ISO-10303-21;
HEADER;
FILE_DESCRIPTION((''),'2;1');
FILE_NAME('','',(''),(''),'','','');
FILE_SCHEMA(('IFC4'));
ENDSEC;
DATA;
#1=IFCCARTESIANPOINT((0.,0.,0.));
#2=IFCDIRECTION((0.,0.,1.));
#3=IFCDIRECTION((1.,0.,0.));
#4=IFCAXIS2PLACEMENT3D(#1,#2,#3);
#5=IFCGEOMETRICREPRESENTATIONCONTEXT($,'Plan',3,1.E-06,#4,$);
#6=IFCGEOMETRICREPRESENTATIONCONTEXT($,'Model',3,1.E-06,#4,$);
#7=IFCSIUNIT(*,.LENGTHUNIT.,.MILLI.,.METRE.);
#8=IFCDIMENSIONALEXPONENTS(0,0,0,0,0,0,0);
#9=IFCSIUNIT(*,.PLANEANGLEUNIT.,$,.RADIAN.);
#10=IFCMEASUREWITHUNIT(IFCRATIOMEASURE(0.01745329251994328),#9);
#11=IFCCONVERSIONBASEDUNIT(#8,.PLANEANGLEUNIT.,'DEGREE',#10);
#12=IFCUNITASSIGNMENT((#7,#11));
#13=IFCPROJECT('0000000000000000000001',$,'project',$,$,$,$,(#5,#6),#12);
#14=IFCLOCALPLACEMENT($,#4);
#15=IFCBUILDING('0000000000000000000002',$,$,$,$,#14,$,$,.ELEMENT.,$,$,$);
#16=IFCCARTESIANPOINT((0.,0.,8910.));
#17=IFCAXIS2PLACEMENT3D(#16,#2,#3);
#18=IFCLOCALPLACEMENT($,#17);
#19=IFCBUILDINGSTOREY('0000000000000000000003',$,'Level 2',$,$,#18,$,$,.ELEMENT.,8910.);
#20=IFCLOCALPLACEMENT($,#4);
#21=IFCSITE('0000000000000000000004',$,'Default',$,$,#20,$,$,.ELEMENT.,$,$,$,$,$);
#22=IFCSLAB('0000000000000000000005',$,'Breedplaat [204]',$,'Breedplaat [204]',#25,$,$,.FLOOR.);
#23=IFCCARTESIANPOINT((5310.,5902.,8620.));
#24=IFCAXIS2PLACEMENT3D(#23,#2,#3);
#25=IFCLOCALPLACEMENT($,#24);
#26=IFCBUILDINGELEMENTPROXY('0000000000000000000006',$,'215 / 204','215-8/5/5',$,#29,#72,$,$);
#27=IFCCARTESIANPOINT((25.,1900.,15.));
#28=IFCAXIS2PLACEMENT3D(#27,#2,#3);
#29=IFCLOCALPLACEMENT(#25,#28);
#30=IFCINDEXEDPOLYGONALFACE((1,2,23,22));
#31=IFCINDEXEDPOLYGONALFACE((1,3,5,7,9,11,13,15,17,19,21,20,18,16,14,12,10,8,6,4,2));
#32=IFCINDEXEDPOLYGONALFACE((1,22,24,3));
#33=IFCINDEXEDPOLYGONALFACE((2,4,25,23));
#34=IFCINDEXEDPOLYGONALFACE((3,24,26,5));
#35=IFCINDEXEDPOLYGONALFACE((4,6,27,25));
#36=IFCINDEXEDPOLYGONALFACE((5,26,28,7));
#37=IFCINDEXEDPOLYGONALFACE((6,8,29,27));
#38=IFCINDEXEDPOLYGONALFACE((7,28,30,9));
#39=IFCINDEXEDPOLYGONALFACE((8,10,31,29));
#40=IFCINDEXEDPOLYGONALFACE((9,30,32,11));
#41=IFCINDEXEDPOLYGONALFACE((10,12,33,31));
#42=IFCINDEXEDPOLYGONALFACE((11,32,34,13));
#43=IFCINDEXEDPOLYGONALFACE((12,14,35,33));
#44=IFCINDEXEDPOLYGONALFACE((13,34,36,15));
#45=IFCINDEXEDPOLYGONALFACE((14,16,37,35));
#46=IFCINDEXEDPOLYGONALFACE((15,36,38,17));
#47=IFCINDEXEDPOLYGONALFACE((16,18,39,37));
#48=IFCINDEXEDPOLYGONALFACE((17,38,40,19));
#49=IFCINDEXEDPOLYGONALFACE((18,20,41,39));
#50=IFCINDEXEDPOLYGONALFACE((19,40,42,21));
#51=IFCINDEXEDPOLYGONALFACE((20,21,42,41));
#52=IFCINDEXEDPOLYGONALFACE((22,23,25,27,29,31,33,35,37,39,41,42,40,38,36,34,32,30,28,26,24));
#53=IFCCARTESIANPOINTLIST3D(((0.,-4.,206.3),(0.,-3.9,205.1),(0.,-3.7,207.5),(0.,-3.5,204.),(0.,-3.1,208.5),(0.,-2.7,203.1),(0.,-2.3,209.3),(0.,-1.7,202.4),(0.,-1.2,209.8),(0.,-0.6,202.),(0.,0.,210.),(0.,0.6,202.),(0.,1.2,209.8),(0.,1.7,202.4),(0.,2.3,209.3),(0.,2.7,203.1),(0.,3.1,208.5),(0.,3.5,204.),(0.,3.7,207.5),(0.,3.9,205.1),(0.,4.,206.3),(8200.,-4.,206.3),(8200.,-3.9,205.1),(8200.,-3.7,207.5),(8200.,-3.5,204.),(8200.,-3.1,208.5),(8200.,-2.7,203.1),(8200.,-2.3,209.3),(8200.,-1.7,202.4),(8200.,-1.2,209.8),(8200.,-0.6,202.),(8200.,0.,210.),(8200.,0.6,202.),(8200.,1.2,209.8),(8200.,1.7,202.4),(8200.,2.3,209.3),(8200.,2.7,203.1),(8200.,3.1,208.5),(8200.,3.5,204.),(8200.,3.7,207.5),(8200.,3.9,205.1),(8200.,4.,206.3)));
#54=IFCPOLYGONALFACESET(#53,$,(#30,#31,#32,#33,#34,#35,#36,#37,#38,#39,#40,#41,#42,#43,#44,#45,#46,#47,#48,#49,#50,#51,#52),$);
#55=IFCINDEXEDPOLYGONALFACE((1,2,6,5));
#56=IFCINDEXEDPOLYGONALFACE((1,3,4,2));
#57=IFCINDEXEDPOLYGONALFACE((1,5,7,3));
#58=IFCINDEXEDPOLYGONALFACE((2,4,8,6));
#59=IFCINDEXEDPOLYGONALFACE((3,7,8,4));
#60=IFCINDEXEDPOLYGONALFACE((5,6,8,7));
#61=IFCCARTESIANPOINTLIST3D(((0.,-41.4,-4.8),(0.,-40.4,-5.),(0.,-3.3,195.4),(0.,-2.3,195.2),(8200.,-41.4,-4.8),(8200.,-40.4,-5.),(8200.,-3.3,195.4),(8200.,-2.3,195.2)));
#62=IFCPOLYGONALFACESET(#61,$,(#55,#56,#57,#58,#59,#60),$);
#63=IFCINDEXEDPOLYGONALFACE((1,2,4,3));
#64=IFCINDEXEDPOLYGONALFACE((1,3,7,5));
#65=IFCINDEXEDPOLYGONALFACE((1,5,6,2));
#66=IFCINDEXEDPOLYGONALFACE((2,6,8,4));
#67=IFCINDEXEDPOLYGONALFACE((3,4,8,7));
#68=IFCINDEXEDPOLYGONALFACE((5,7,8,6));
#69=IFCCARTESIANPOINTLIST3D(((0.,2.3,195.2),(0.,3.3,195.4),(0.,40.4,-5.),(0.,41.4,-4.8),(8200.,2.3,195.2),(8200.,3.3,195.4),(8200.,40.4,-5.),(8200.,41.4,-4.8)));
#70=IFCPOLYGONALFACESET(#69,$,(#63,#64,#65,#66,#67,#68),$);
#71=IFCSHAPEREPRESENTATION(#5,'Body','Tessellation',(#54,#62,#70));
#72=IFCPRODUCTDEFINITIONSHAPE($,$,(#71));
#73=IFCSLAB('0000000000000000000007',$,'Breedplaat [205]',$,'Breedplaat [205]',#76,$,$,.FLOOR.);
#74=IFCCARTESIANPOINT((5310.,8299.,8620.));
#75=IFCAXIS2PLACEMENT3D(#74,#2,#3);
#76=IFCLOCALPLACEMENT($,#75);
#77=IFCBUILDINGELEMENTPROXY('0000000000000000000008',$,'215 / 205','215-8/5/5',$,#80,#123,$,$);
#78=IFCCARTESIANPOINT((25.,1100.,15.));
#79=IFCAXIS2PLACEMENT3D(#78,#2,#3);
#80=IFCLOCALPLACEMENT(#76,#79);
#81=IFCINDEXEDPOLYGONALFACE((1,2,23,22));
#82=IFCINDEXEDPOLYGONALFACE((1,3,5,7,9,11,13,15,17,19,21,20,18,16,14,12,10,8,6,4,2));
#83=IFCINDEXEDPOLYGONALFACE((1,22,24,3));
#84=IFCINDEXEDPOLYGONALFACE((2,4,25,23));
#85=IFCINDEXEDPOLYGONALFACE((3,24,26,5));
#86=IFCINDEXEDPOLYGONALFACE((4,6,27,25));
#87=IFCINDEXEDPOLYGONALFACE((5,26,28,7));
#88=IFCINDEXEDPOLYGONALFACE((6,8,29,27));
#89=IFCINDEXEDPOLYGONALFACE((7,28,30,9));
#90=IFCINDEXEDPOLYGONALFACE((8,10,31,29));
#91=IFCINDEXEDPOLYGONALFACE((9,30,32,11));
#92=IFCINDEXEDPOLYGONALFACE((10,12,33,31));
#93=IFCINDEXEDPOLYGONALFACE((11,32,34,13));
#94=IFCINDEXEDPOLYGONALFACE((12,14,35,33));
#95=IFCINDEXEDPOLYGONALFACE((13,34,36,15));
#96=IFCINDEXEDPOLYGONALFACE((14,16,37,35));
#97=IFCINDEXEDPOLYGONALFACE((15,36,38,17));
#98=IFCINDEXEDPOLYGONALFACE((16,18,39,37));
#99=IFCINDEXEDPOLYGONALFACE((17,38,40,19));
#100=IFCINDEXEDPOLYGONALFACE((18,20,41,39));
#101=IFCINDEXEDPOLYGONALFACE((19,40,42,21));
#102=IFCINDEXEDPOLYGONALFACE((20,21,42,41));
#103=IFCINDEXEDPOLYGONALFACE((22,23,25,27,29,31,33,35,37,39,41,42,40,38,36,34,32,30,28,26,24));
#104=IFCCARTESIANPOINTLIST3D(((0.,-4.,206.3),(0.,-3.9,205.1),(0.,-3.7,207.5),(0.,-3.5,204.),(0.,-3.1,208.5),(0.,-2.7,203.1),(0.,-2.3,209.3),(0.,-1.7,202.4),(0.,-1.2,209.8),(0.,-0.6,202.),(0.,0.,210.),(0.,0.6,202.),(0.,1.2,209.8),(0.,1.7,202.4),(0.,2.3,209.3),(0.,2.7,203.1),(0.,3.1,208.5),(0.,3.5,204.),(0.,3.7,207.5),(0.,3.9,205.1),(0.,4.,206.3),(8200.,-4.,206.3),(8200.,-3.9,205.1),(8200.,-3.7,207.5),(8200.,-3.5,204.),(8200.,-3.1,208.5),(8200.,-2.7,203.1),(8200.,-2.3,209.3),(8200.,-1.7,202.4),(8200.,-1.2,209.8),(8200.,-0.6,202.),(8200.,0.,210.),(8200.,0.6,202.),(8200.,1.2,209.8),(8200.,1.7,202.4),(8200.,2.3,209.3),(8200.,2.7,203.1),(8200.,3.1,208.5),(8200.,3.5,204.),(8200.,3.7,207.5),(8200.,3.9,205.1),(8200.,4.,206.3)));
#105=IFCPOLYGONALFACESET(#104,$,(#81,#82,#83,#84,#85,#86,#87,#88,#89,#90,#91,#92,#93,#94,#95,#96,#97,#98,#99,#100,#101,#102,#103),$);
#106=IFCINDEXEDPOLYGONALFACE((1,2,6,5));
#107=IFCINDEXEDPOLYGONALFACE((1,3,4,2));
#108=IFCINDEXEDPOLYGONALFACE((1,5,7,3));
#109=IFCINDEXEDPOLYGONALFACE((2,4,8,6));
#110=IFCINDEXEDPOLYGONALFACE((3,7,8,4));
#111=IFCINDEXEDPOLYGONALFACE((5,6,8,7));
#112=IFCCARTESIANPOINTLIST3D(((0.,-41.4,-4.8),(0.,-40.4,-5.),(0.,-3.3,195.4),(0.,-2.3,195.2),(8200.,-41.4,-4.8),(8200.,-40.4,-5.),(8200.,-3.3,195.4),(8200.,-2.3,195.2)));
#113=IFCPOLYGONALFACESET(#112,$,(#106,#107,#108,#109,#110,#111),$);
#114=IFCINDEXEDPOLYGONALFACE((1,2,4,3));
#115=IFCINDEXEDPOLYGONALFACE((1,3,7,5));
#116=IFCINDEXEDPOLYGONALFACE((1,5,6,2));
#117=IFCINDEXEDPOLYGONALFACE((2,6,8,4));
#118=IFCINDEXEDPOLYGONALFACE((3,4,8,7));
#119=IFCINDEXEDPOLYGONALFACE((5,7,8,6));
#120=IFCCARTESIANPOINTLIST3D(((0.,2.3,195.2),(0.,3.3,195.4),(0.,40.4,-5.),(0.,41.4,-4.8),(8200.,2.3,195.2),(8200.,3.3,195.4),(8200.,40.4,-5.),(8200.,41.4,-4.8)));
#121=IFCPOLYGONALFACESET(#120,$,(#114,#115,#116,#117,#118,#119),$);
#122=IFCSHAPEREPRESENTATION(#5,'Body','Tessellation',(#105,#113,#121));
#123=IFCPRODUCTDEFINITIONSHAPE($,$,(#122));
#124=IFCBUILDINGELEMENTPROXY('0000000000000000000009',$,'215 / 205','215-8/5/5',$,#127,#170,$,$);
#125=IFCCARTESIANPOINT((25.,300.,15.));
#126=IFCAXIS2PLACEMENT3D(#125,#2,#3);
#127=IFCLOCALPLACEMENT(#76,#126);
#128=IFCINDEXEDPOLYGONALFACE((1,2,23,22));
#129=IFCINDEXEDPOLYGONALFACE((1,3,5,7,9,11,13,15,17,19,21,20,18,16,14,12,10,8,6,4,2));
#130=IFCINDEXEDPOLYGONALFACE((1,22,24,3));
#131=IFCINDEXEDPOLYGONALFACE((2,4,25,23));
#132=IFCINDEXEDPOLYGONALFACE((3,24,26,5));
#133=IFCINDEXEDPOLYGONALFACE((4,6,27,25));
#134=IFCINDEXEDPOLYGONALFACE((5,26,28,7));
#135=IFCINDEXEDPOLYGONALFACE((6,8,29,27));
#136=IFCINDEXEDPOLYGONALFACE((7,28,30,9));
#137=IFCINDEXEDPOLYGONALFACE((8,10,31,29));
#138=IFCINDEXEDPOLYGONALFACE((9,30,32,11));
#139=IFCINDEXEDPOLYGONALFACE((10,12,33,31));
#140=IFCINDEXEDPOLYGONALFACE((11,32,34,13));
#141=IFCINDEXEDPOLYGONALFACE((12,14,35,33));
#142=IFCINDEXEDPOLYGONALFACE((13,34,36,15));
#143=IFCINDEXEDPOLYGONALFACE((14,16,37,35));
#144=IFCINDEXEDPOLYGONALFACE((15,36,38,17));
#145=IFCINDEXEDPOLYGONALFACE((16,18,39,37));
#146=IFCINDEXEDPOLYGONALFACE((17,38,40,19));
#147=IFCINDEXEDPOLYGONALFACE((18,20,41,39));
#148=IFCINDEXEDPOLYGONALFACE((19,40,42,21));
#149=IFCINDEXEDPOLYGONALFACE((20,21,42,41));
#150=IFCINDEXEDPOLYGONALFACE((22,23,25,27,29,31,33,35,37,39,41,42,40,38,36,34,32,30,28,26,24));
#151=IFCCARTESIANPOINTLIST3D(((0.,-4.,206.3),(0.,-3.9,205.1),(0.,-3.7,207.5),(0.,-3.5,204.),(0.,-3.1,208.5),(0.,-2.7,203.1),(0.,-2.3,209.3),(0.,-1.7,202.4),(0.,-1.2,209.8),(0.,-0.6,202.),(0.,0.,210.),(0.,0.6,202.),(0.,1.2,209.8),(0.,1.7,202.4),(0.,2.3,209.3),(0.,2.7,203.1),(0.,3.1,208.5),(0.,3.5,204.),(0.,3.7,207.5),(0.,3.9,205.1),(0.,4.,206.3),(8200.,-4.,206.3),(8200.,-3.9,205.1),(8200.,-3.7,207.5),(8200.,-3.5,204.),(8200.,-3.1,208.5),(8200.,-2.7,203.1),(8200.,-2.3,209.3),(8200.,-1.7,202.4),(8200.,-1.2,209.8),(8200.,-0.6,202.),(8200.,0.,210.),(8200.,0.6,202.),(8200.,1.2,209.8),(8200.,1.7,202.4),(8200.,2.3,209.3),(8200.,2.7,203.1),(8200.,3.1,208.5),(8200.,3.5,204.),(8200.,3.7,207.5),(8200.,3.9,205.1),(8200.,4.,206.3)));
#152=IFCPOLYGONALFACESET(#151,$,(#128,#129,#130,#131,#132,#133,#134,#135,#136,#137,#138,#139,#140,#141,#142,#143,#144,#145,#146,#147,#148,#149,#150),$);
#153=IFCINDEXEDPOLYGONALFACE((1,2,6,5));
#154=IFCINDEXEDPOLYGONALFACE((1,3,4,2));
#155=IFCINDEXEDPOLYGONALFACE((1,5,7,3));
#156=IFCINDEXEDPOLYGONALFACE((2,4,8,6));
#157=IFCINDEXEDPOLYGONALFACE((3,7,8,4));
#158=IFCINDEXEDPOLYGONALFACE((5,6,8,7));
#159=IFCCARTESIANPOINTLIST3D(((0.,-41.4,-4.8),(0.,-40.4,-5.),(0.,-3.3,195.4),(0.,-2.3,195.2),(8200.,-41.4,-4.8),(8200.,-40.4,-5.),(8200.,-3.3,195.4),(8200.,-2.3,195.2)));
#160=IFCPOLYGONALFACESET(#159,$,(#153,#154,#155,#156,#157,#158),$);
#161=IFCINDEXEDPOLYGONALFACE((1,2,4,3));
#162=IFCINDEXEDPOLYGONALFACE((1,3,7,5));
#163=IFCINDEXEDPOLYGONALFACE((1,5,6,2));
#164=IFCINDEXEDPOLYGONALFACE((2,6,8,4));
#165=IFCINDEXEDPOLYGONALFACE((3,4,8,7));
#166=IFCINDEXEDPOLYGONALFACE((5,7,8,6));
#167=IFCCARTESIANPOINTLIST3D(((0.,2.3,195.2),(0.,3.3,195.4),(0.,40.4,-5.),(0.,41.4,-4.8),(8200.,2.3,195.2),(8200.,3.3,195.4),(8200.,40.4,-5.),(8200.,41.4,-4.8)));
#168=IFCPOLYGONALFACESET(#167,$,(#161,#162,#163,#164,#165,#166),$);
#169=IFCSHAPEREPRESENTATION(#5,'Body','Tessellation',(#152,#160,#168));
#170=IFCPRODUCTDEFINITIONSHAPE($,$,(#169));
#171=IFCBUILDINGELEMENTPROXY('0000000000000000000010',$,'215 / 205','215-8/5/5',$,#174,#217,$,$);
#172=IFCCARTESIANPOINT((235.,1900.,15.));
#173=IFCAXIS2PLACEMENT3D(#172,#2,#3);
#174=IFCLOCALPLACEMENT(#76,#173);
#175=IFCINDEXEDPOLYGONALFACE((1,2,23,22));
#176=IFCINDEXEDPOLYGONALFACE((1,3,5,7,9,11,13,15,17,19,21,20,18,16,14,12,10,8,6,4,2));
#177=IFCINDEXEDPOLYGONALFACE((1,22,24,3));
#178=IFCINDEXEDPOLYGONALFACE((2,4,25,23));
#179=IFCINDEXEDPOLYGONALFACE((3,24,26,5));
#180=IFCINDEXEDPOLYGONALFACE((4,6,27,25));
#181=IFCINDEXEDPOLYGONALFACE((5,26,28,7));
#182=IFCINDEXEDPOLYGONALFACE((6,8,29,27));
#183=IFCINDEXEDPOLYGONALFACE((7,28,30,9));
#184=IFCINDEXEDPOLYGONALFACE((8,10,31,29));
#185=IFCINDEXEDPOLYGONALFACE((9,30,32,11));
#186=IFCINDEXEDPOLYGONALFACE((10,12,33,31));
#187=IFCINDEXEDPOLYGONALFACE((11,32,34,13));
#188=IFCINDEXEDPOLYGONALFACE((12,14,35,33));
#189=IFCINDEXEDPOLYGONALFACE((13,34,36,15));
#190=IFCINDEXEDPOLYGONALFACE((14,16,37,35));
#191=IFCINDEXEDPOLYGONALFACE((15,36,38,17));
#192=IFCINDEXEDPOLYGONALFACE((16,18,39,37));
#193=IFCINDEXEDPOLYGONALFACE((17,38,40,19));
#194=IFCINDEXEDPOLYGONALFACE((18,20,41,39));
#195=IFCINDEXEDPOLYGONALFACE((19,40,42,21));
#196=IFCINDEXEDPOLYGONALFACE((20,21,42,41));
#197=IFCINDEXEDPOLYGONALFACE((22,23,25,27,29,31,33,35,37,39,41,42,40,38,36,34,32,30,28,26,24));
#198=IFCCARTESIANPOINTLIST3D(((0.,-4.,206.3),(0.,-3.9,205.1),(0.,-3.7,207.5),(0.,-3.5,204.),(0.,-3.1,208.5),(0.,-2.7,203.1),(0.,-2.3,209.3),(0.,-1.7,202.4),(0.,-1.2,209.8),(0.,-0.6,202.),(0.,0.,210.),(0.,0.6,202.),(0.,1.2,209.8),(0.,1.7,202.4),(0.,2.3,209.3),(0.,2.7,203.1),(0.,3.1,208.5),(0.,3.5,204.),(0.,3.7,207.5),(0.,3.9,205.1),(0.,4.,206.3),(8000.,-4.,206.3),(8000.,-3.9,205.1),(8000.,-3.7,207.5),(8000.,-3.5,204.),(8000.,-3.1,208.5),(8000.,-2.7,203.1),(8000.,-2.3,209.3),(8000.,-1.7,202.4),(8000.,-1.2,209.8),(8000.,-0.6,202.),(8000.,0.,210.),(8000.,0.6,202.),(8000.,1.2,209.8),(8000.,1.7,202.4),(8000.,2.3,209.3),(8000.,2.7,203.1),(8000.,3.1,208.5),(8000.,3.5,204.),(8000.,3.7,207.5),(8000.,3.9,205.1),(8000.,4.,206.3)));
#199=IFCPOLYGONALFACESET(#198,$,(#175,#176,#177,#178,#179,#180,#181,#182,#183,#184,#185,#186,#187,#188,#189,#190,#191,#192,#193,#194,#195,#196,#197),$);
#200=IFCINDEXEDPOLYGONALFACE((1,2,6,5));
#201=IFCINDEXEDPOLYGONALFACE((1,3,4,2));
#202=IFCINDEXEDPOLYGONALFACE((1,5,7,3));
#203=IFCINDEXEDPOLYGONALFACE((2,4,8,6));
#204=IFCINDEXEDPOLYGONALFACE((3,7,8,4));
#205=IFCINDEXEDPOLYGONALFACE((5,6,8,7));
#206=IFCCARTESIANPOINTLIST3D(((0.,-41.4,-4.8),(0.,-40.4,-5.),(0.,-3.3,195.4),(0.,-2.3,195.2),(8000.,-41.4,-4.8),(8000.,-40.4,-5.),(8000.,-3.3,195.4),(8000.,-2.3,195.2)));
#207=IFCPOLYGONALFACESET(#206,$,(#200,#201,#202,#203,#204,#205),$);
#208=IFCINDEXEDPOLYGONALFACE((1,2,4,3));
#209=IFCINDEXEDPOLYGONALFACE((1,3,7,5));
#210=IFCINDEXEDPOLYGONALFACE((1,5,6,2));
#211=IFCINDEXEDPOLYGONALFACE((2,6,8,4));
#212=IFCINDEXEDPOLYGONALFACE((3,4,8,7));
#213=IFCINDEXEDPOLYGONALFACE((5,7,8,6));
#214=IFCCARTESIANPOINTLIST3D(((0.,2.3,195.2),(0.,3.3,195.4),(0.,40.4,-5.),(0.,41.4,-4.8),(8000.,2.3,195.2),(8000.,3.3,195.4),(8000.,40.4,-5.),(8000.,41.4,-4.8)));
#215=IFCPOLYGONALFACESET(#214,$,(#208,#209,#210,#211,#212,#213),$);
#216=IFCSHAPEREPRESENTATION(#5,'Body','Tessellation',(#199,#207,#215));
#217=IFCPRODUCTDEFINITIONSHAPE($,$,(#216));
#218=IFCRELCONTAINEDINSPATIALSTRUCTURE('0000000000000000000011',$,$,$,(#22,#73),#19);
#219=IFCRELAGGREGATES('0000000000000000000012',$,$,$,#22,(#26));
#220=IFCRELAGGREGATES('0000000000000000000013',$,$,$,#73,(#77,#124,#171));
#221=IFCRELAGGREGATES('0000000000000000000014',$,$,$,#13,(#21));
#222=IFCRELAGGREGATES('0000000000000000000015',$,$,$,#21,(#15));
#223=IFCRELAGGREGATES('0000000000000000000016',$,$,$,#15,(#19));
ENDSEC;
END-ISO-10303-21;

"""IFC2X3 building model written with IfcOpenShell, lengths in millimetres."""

from ifc_helpers import new_model, entity, si_unit, converted_unit, frame, origin_with_axes, origin_2d_with_axis, place, context, project, spatial, rectangle, circle, extrude, element, aggregate, save


model = new_model("IFC2X3")

# Units and contexts
plan_context = context("Plan", 3, precision=1e-06, world=origin_with_axes())
model_context = context("Model", 3, precision=1e-06, world=origin_with_axes())
ifc_project = project(units=[si_unit("LENGTHUNIT", "METRE", prefix="MILLI"), converted_unit("PLANEANGLEUNIT", "DEGREE", entity("IfcRatioMeasure", 0.01745329251994328), si_unit("PLANEANGLEUNIT", "RADIAN"), dimensions=[0, 0, 0, 0, 0, 0, 0])], contexts=[plan_context, model_context])

# Site, building, storey
site_placement = place(None, origin_with_axes())
site = spatial("IfcSite", under=ifc_project, at=site_placement, Name="Default", CompositionType="ELEMENT")
building_placement = place(None, origin_with_axes())
building = spatial("IfcBuilding", under=site, at=building_placement, CompositionType="ELEMENT")
storey_placement = place(None, frame((0.0, 0.0, 8910.0), z_axis=(0.0, 0.0, 1.0), x_axis=(1.0, 0.0, 0.0)))
storey = spatial("IfcBuildingStorey", under=building, at=storey_placement, Name="Level 2", CompositionType="ELEMENT", Elevation=8910.0)

# Slab, building element proxy
slab_1_placement = place(None, frame((5310.0, 5902.0, 8620.0), z_axis=(0.0, 0.0, 1.0), x_axis=(1.0, 0.0, 0.0)))
slab_1 = element("IfcSlab", 1, at=slab_1_placement, inside=storey, Name="Breedplaat [204]", ObjectType="Breedplaat [204]", PredefinedType="FLOOR")
proxy_1_placement = place(slab_1_placement, frame((25.0, 1900.0, 15.0), z_axis=(0.0, 0.0, 1.0), x_axis=(1.0, 0.0, 0.0)))
proxy_1 = element("IfcBuildingElementProxy", 2, at=proxy_1_placement, Name="215 / 204", Description="215-8/5/5", context=plan_context, shape_type="SweptSolid", body=[
    extrude(circle(Radius=4.0, at=origin_2d_with_axis()), frame((0.0, 0.0, 206.0), z_axis=(1.0, 0.0, 0.0), x_axis=(0.0, 0.0, 1.0)), (0.0, 0.0, 1.0), 8200.0),
    extrude(rectangle(XDim=203.8, YDim=1.0, at=origin_2d_with_axis()), frame((0.0, -21.9, 95.2), z_axis=(1.0, 0.0, 0.0), x_axis=(0.0, 0.187112, 0.982339)), (0.0, 0.0, 1.0), 8200.0),
    extrude(rectangle(XDim=203.8, YDim=1.0, at=origin_2d_with_axis()), frame((0.0, 21.9, 95.2), z_axis=(1.0, 0.0, 0.0), x_axis=(0.0, -0.187112, 0.982339)), (0.0, 0.0, 1.0), 8200.0),
])
aggregate(slab_1, [proxy_1])

# Slab, building element proxies
slab_2_placement = place(None, frame((5310.0, 8299.0, 8620.0), z_axis=(0.0, 0.0, 1.0), x_axis=(1.0, 0.0, 0.0)))
slab_2 = element("IfcSlab", 3, at=slab_2_placement, inside=storey, Name="Breedplaat [205]", ObjectType="Breedplaat [205]", PredefinedType="FLOOR")
proxy_2_placement = place(slab_2_placement, frame((25.0, 1100.0, 15.0), z_axis=(0.0, 0.0, 1.0), x_axis=(1.0, 0.0, 0.0)))
proxy_2 = element("IfcBuildingElementProxy", 4, at=proxy_2_placement, Name="215 / 205", Description="215-8/5/5", context=plan_context, shape_type="SweptSolid", body=[
    extrude(circle(Radius=4.0, at=origin_2d_with_axis()), frame((0.0, 0.0, 206.0), z_axis=(1.0, 0.0, 0.0), x_axis=(0.0, 0.0, 1.0)), (0.0, 0.0, 1.0), 8200.0),
    extrude(rectangle(XDim=203.8, YDim=1.0, at=origin_2d_with_axis()), frame((0.0, -21.9, 95.2), z_axis=(1.0, 0.0, 0.0), x_axis=(0.0, 0.187112, 0.982339)), (0.0, 0.0, 1.0), 8200.0),
    extrude(rectangle(XDim=203.8, YDim=1.0, at=origin_2d_with_axis()), frame((0.0, 21.9, 95.2), z_axis=(1.0, 0.0, 0.0), x_axis=(0.0, -0.187112, 0.982339)), (0.0, 0.0, 1.0), 8200.0),
])
proxy_3_placement = place(slab_2_placement, frame((25.0, 300.0, 15.0), z_axis=(0.0, 0.0, 1.0), x_axis=(1.0, 0.0, 0.0)))
proxy_3 = element("IfcBuildingElementProxy", 5, at=proxy_3_placement, Name="215 / 205", Description="215-8/5/5", context=plan_context, shape_type="SweptSolid", body=[
    extrude(circle(Radius=4.0, at=origin_2d_with_axis()), frame((0.0, 0.0, 206.0), z_axis=(1.0, 0.0, 0.0), x_axis=(0.0, 0.0, 1.0)), (0.0, 0.0, 1.0), 8200.0),
    extrude(rectangle(XDim=203.8, YDim=1.0, at=origin_2d_with_axis()), frame((0.0, -21.9, 95.2), z_axis=(1.0, 0.0, 0.0), x_axis=(0.0, 0.187112, 0.982339)), (0.0, 0.0, 1.0), 8200.0),
    extrude(rectangle(XDim=203.8, YDim=1.0, at=origin_2d_with_axis()), frame((0.0, 21.9, 95.2), z_axis=(1.0, 0.0, 0.0), x_axis=(0.0, -0.187112, 0.982339)), (0.0, 0.0, 1.0), 8200.0),
])
proxy_4_placement = place(slab_2_placement, frame((235.0, 1900.0, 15.0), z_axis=(0.0, 0.0, 1.0), x_axis=(1.0, 0.0, 0.0)))
proxy_4 = element("IfcBuildingElementProxy", 6, at=proxy_4_placement, Name="215 / 205", Description="215-8/5/5", context=plan_context, shape_type="SweptSolid", body=[
    extrude(circle(Radius=4.0, at=origin_2d_with_axis()), frame((0.0, 0.0, 206.0), z_axis=(1.0, 0.0, 0.0), x_axis=(0.0, 0.0, 1.0)), (0.0, 0.0, 1.0), 8000.0),
    extrude(rectangle(XDim=203.8, YDim=1.0, at=origin_2d_with_axis()), frame((0.0, -21.9, 95.2), z_axis=(1.0, 0.0, 0.0), x_axis=(0.0, 0.187112, 0.982339)), (0.0, 0.0, 1.0), 8000.0),
    extrude(rectangle(XDim=203.8, YDim=1.0, at=origin_2d_with_axis()), frame((0.0, 21.9, 95.2), z_axis=(1.0, 0.0, 0.0), x_axis=(0.0, -0.187112, 0.982339)), (0.0, 0.0, 1.0), 8000.0),
])
aggregate(slab_2, [proxy_2, proxy_3, proxy_4])

save(model, "model.ifc")
